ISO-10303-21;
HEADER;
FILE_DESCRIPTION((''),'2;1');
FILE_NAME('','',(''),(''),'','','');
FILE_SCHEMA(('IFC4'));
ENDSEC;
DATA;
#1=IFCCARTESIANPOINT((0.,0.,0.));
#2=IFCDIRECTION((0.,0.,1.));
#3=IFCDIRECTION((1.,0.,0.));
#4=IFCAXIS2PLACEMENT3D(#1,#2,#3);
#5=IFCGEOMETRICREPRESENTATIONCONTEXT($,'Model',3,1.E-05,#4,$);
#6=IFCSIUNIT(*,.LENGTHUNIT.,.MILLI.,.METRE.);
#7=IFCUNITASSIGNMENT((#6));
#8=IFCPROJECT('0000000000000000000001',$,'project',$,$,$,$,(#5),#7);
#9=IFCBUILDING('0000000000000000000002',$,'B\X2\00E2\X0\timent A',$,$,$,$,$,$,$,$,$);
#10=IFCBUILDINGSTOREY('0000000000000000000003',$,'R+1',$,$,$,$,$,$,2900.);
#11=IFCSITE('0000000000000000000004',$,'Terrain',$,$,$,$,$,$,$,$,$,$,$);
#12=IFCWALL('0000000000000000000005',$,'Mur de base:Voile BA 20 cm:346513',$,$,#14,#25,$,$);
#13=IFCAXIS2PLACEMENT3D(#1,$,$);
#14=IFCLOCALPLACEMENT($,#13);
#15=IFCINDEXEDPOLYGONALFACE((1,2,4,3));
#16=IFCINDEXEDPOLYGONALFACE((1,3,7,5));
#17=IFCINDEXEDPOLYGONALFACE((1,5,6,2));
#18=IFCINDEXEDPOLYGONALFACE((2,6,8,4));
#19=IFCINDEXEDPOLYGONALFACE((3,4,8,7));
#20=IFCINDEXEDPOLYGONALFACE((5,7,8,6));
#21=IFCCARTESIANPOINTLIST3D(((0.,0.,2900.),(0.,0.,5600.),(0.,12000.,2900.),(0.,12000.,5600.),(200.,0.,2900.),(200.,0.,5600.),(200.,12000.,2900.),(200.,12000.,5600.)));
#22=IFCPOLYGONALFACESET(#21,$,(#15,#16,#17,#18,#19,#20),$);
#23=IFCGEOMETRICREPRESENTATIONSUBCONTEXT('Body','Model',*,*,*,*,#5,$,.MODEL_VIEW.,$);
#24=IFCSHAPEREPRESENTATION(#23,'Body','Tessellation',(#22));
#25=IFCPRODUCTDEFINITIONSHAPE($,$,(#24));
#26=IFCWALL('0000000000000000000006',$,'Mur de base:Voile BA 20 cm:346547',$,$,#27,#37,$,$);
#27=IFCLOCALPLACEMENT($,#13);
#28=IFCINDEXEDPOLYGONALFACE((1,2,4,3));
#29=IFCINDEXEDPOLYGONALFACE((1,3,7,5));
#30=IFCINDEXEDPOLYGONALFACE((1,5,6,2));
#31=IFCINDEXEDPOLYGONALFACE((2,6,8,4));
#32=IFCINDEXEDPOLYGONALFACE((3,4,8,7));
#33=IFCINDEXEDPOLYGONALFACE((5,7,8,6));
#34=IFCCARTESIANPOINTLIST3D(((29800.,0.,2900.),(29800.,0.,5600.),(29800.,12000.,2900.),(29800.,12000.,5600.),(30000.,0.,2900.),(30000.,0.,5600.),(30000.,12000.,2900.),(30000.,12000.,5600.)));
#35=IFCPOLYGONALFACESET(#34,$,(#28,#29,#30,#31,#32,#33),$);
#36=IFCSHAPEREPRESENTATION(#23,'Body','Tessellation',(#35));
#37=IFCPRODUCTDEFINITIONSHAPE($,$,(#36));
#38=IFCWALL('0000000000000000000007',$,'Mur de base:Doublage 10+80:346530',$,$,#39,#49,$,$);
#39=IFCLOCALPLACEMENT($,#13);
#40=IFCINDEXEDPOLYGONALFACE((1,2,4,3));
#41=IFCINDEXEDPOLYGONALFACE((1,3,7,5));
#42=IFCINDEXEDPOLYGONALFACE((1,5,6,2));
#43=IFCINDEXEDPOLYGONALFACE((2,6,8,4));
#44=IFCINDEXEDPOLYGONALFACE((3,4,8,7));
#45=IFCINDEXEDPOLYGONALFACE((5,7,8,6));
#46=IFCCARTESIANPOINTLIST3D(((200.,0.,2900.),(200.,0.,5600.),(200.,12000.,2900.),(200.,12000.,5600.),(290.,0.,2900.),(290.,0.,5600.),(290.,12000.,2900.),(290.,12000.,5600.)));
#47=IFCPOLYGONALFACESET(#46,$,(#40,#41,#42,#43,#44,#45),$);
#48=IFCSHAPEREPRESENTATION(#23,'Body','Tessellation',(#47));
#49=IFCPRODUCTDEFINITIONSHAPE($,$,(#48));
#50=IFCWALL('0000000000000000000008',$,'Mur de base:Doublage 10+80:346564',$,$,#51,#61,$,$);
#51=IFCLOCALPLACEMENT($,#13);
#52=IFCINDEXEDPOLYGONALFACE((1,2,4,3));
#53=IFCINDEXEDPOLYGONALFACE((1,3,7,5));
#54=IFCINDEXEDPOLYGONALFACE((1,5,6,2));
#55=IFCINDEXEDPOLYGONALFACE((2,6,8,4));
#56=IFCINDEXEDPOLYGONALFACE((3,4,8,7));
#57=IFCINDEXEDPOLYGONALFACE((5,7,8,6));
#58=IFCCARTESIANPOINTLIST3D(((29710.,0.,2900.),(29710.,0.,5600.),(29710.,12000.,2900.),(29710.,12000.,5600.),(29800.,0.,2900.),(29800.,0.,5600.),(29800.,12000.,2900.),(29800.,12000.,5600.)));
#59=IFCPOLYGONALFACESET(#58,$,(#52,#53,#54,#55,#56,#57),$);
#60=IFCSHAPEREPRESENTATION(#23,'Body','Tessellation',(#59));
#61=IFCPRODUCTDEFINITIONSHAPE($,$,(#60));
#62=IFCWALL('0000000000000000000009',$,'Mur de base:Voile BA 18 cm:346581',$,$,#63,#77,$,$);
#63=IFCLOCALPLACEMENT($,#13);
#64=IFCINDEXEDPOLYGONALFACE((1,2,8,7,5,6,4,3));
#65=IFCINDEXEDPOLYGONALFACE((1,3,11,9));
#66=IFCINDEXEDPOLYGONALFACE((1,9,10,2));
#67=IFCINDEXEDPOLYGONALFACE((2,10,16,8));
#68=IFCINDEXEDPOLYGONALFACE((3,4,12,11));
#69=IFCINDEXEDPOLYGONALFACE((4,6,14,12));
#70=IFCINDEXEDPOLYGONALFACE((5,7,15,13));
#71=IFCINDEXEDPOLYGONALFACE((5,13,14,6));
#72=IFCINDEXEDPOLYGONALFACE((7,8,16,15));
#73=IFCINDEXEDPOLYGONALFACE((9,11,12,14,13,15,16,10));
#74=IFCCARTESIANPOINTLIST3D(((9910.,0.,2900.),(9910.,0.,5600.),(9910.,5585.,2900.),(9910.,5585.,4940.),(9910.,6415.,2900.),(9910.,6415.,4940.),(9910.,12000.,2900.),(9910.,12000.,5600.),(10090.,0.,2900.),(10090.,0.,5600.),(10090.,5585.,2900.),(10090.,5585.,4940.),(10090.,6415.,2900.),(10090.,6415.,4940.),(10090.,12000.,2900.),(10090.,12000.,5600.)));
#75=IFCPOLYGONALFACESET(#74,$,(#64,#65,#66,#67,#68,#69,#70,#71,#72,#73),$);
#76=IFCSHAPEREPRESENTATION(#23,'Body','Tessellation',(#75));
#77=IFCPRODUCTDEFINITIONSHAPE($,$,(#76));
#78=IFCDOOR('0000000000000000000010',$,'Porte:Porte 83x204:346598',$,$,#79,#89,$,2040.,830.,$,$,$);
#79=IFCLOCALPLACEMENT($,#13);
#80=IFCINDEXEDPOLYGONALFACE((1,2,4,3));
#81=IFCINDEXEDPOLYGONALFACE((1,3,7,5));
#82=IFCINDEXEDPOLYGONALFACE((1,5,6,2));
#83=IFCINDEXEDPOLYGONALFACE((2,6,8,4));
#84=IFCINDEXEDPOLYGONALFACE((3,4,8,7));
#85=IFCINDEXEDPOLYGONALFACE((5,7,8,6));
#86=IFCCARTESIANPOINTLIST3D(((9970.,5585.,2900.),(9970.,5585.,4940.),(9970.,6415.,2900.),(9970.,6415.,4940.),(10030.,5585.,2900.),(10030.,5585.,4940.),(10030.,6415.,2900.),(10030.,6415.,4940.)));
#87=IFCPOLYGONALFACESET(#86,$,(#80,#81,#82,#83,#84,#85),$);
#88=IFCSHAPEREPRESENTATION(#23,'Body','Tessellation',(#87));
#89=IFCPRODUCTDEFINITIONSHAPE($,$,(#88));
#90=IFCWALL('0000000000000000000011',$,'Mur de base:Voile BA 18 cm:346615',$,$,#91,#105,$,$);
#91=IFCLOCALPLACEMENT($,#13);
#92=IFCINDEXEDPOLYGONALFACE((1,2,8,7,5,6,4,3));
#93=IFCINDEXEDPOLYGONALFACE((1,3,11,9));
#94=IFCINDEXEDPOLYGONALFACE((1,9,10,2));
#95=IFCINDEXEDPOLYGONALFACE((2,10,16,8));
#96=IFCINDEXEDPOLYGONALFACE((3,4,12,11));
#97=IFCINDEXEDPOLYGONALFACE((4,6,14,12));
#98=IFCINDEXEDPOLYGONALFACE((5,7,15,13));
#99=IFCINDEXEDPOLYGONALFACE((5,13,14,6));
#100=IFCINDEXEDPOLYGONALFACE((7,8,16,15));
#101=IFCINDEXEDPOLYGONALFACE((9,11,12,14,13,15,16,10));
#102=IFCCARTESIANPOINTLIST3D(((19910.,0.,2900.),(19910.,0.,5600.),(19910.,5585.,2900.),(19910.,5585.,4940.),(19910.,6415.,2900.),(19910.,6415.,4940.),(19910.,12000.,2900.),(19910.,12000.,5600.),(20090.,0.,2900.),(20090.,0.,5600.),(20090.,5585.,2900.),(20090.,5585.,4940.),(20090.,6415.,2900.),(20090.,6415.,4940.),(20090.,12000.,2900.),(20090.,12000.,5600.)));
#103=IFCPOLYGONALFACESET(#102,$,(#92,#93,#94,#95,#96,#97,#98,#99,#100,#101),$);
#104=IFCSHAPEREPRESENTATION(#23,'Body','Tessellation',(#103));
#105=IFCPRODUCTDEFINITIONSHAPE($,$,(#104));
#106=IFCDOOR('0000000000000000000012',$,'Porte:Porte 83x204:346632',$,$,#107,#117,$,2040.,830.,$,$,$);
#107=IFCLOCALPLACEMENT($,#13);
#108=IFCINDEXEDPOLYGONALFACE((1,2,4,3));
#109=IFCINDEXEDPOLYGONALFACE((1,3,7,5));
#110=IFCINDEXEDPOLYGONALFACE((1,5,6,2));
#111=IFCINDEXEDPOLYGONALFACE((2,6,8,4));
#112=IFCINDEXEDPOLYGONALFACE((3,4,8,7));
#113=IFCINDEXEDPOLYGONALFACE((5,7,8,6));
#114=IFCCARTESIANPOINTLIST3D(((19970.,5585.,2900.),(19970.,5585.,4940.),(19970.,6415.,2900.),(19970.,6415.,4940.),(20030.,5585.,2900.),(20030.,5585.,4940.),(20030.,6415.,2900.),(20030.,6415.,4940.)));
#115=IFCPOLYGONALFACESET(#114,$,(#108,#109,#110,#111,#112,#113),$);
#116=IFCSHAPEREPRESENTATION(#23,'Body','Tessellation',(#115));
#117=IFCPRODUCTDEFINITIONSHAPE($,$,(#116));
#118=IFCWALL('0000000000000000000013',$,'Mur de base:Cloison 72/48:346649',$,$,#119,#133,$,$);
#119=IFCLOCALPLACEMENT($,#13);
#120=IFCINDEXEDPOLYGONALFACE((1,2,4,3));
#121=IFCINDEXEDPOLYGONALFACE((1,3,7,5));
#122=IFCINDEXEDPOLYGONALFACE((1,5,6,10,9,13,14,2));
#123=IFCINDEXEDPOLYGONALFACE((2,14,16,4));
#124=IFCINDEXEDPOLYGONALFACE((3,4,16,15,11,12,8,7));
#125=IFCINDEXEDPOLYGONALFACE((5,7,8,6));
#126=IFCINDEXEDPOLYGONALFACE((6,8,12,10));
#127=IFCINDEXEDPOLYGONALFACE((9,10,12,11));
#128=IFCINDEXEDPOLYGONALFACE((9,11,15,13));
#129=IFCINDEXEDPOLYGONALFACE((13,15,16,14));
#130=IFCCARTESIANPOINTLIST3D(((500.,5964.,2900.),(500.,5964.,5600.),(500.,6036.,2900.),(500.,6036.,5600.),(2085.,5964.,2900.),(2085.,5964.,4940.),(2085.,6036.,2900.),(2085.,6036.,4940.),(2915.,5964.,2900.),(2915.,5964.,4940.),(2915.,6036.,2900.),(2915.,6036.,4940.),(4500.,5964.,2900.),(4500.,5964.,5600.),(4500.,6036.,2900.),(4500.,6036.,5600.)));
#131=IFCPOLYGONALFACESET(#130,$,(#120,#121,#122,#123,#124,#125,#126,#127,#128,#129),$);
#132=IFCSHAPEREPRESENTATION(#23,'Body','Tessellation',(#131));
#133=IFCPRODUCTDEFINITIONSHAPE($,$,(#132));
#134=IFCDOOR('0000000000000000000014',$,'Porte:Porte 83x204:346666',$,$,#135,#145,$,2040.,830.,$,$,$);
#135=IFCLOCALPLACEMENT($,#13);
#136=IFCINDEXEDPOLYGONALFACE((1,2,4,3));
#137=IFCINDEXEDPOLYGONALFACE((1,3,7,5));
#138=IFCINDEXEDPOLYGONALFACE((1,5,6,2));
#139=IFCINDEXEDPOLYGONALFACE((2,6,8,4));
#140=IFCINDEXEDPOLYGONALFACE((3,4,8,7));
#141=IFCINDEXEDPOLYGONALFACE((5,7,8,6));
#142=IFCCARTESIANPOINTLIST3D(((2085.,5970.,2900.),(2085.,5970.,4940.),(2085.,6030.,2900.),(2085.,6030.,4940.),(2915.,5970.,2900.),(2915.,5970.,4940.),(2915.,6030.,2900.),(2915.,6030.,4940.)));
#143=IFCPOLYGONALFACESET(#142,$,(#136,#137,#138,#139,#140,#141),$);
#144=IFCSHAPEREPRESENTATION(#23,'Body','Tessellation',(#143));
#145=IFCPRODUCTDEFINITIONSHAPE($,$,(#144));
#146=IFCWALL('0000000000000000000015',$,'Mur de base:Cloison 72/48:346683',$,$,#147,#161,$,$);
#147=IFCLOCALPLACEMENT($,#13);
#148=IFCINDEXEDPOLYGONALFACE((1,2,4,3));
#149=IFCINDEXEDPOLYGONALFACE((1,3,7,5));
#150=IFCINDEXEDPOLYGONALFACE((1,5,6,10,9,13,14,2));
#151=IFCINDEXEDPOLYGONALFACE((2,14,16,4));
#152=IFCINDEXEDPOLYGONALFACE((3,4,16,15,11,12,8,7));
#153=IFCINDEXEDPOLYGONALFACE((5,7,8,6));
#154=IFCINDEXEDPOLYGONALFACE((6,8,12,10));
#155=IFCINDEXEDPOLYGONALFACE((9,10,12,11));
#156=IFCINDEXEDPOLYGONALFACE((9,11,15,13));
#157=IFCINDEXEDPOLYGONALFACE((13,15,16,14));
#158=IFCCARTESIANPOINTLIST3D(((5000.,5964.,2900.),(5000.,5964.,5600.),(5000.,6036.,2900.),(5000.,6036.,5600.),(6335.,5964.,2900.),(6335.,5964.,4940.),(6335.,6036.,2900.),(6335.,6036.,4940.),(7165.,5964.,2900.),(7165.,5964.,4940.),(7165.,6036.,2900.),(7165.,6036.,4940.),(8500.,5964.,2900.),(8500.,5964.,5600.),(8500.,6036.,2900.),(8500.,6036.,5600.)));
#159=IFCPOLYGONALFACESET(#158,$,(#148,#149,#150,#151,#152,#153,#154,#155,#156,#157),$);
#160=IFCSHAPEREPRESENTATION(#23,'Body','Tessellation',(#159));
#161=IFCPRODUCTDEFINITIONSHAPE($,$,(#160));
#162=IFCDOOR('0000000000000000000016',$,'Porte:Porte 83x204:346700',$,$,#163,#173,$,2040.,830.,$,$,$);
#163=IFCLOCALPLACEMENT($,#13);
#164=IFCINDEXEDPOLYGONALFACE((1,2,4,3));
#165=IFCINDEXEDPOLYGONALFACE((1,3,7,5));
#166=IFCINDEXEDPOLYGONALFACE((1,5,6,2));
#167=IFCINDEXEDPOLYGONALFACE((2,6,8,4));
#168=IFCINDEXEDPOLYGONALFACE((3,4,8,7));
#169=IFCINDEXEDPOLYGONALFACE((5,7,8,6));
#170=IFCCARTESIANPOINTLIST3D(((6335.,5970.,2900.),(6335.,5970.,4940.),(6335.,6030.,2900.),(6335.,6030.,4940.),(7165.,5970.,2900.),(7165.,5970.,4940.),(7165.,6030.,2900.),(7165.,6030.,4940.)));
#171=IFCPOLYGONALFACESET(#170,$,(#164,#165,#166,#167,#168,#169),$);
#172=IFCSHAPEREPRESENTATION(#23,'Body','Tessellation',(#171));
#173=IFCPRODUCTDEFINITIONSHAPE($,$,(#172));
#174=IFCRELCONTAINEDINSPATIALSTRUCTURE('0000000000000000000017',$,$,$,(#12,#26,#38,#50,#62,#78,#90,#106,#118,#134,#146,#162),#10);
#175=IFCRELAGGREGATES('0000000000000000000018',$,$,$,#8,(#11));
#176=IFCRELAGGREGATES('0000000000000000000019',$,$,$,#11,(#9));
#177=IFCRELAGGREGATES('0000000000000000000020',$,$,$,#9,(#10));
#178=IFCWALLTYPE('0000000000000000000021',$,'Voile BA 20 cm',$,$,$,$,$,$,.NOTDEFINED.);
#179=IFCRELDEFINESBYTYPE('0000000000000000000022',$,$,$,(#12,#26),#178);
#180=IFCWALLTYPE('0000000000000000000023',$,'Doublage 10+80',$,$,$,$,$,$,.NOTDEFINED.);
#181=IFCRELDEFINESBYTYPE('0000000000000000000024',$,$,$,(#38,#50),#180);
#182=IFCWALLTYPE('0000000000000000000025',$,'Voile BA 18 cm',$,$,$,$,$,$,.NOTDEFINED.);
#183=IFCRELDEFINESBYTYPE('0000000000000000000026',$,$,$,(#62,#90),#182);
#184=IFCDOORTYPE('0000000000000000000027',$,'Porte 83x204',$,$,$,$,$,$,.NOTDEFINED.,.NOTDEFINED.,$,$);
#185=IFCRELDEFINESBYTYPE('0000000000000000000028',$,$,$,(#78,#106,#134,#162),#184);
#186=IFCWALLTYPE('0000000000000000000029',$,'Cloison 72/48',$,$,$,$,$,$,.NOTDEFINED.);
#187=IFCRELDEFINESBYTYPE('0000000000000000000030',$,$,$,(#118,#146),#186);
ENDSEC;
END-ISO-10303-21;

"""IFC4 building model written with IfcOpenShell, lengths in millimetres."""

from ifc_helpers import new_model, si_unit, frame, frame_2d, origin_with_axes, place, context, subcontext, project, spatial, rectangle, extrude, type_object, element, fill, save


model = new_model("IFC4")

# Units and contexts
model_context = context("Model", 3, precision=1e-05, world=origin_with_axes())
body_context = subcontext(model_context, "Body", "Model", "MODEL_VIEW")
ifc_project = project(units=[si_unit("LENGTHUNIT", "METRE", prefix="MILLI")], contexts=[model_context])

# Site, building, storey
site = spatial("IfcSite", under=ifc_project, Name="Terrain")
building = spatial("IfcBuilding", under=site, Name="Bâtiment A")
storey = spatial("IfcBuildingStorey", under=building, Name="R+1", Elevation=2900.0)

# Walls
wall_type_1 = type_object("IfcWallType", Name="Voile BA 20 cm", PredefinedType="NOTDEFINED")
wall_1_placement = place(None, origin_with_axes())
element("IfcWall", 1, at=wall_1_placement, inside=storey, type_object=wall_type_1, Name="Mur de base:Voile BA 20 cm:346513", context=body_context, shape_type="SweptSolid", body=[
    extrude(rectangle(XDim=200.0, YDim=12000.0, at=frame_2d((100.0, 6000.0))), frame((0.0, 0.0, 2900.0), z_axis=(0.0, 0.0, 1.0), x_axis=(1.0, 0.0, 0.0)), (0.0, 0.0, 1.0), 2700.0),
])
wall_2_placement = place(None, origin_with_axes())
element("IfcWall", 2, at=wall_2_placement, inside=storey, type_object=wall_type_1, Name="Mur de base:Voile BA 20 cm:346547", context=body_context, shape_type="SweptSolid", body=[
    extrude(rectangle(XDim=200.0, YDim=12000.0, at=frame_2d((29900.0, 6000.0))), frame((0.0, 0.0, 2900.0), z_axis=(0.0, 0.0, 1.0), x_axis=(1.0, 0.0, 0.0)), (0.0, 0.0, 1.0), 2700.0),
])
wall_type_2 = type_object("IfcWallType", Name="Doublage 10+80", PredefinedType="NOTDEFINED")
wall_3_placement = place(None, origin_with_axes())
element("IfcWall", 3, at=wall_3_placement, inside=storey, type_object=wall_type_2, Name="Mur de base:Doublage 10+80:346530", context=body_context, shape_type="SweptSolid", body=[
    extrude(rectangle(XDim=90.0, YDim=12000.0, at=frame_2d((245.0, 6000.0))), frame((0.0, 0.0, 2900.0), z_axis=(0.0, 0.0, 1.0), x_axis=(1.0, 0.0, 0.0)), (0.0, 0.0, 1.0), 2700.0),
])
wall_4_placement = place(None, origin_with_axes())
element("IfcWall", 4, at=wall_4_placement, inside=storey, type_object=wall_type_2, Name="Mur de base:Doublage 10+80:346564", context=body_context, shape_type="SweptSolid", body=[
    extrude(rectangle(XDim=90.0, YDim=12000.0, at=frame_2d((29755.0, 6000.0))), frame((0.0, 0.0, 2900.0), z_axis=(0.0, 0.0, 1.0), x_axis=(1.0, 0.0, 0.0)), (0.0, 0.0, 1.0), 2700.0),
])

# Walls, openings, doors
wall_type_3 = type_object("IfcWallType", Name="Voile BA 18 cm", PredefinedType="NOTDEFINED")
wall_5_placement = place(None, origin_with_axes())
wall_5 = element("IfcWall", 5, at=wall_5_placement, inside=storey, type_object=wall_type_3, Name="Mur de base:Voile BA 18 cm:346581", context=body_context, shape_type="SweptSolid", body=[
    extrude(rectangle(XDim=180.0, YDim=12000.0, at=frame_2d((10000.0, 6000.0))), frame((0.0, 0.0, 2900.0), z_axis=(0.0, 0.0, 1.0), x_axis=(1.0, 0.0, 0.0)), (0.0, 0.0, 1.0), 2700.0),
])
opening_1_placement = place(None, origin_with_axes())
opening_1 = element("IfcOpeningElement", 6, at=opening_1_placement, cuts=wall_5, context=body_context, shape_type="SweptSolid", body=[
    extrude(rectangle(XDim=300.0, YDim=830.0, at=frame_2d((10000.0, 6000.0))), frame((0.0, 0.0, 2900.0), z_axis=(0.0, 0.0, 1.0), x_axis=(1.0, 0.0, 0.0)), (0.0, 0.0, 1.0), 2040.0),
])
door_type = type_object("IfcDoorType", Name="Porte 83x204", OperationType="NOTDEFINED", PredefinedType="NOTDEFINED")
door_1_placement = place(None, origin_with_axes())
door_1 = element("IfcDoor", 7, at=door_1_placement, inside=storey, type_object=door_type, Name="Porte:Porte 83x204:346598", OverallHeight=2040.0, OverallWidth=830.0, context=body_context, shape_type="SweptSolid", body=[
    extrude(rectangle(XDim=60.0, YDim=830.0, at=frame_2d((10000.0, 6000.0))), frame((0.0, 0.0, 2900.0), z_axis=(0.0, 0.0, 1.0), x_axis=(1.0, 0.0, 0.0)), (0.0, 0.0, 1.0), 2040.0),
])
fill(opening_1, door_1)
wall_6_placement = place(None, origin_with_axes())
wall_6 = element("IfcWall", 8, at=wall_6_placement, inside=storey, type_object=wall_type_3, Name="Mur de base:Voile BA 18 cm:346615", context=body_context, shape_type="SweptSolid", body=[
    extrude(rectangle(XDim=180.0, YDim=12000.0, at=frame_2d((20000.0, 6000.0))), frame((0.0, 0.0, 2900.0), z_axis=(0.0, 0.0, 1.0), x_axis=(1.0, 0.0, 0.0)), (0.0, 0.0, 1.0), 2700.0),
])
opening_2_placement = place(None, origin_with_axes())
opening_2 = element("IfcOpeningElement", 9, at=opening_2_placement, cuts=wall_6, context=body_context, shape_type="SweptSolid", body=[
    extrude(rectangle(XDim=300.0, YDim=830.0, at=frame_2d((20000.0, 6000.0))), frame((0.0, 0.0, 2900.0), z_axis=(0.0, 0.0, 1.0), x_axis=(1.0, 0.0, 0.0)), (0.0, 0.0, 1.0), 2040.0),
])
door_2_placement = place(None, origin_with_axes())
door_2 = element("IfcDoor", 10, at=door_2_placement, inside=storey, type_object=door_type, Name="Porte:Porte 83x204:346632", OverallHeight=2040.0, OverallWidth=830.0, context=body_context, shape_type="SweptSolid", body=[
    extrude(rectangle(XDim=60.0, YDim=830.0, at=frame_2d((20000.0, 6000.0))), frame((0.0, 0.0, 2900.0), z_axis=(0.0, 0.0, 1.0), x_axis=(1.0, 0.0, 0.0)), (0.0, 0.0, 1.0), 2040.0),
])
fill(opening_2, door_2)
wall_type_4 = type_object("IfcWallType", Name="Cloison 72/48", PredefinedType="NOTDEFINED")
wall_7_placement = place(None, origin_with_axes())
wall_7 = element("IfcWall", 11, at=wall_7_placement, inside=storey, type_object=wall_type_4, Name="Mur de base:Cloison 72/48:346649", context=body_context, shape_type="SweptSolid", body=[
    extrude(rectangle(XDim=4000.0, YDim=72.0, at=frame_2d((2500.0, 6000.0))), frame((0.0, 0.0, 2900.0), z_axis=(0.0, 0.0, 1.0), x_axis=(1.0, 0.0, 0.0)), (0.0, 0.0, 1.0), 2700.0),
])
opening_3_placement = place(None, origin_with_axes())
opening_3 = element("IfcOpeningElement", 12, at=opening_3_placement, cuts=wall_7, context=body_context, shape_type="SweptSolid", body=[
    extrude(rectangle(XDim=830.0, YDim=192.0, at=frame_2d((2500.0, 6000.0))), frame((0.0, 0.0, 2900.0), z_axis=(0.0, 0.0, 1.0), x_axis=(1.0, 0.0, 0.0)), (0.0, 0.0, 1.0), 2040.0),
])
door_3_placement = place(None, origin_with_axes())
door_3 = element("IfcDoor", 13, at=door_3_placement, inside=storey, type_object=door_type, Name="Porte:Porte 83x204:346666", OverallHeight=2040.0, OverallWidth=830.0, context=body_context, shape_type="SweptSolid", body=[
    extrude(rectangle(XDim=830.0, YDim=60.0, at=frame_2d((2500.0, 6000.0))), frame((0.0, 0.0, 2900.0), z_axis=(0.0, 0.0, 1.0), x_axis=(1.0, 0.0, 0.0)), (0.0, 0.0, 1.0), 2040.0),
])
fill(opening_3, door_3)
wall_8_placement = place(None, origin_with_axes())
wall_8 = element("IfcWall", 14, at=wall_8_placement, inside=storey, type_object=wall_type_4, Name="Mur de base:Cloison 72/48:346683", context=body_context, shape_type="SweptSolid", body=[
    extrude(rectangle(XDim=3500.0, YDim=72.0, at=frame_2d((6750.0, 6000.0))), frame((0.0, 0.0, 2900.0), z_axis=(0.0, 0.0, 1.0), x_axis=(1.0, 0.0, 0.0)), (0.0, 0.0, 1.0), 2700.0),
])
opening_4_placement = place(None, origin_with_axes())
opening_4 = element("IfcOpeningElement", 15, at=opening_4_placement, cuts=wall_8, context=body_context, shape_type="SweptSolid", body=[
    extrude(rectangle(XDim=830.0, YDim=192.0, at=frame_2d((6750.0, 6000.0))), frame((0.0, 0.0, 2900.0), z_axis=(0.0, 0.0, 1.0), x_axis=(1.0, 0.0, 0.0)), (0.0, 0.0, 1.0), 2040.0),
])
door_4_placement = place(None, origin_with_axes())
door_4 = element("IfcDoor", 16, at=door_4_placement, inside=storey, type_object=door_type, Name="Porte:Porte 83x204:346700", OverallHeight=2040.0, OverallWidth=830.0, context=body_context, shape_type="SweptSolid", body=[
    extrude(rectangle(XDim=830.0, YDim=60.0, at=frame_2d((6750.0, 6000.0))), frame((0.0, 0.0, 2900.0), z_axis=(0.0, 0.0, 1.0), x_axis=(1.0, 0.0, 0.0)), (0.0, 0.0, 1.0), 2040.0),
])
fill(opening_4, door_4)

save(model, "model.ifc")
